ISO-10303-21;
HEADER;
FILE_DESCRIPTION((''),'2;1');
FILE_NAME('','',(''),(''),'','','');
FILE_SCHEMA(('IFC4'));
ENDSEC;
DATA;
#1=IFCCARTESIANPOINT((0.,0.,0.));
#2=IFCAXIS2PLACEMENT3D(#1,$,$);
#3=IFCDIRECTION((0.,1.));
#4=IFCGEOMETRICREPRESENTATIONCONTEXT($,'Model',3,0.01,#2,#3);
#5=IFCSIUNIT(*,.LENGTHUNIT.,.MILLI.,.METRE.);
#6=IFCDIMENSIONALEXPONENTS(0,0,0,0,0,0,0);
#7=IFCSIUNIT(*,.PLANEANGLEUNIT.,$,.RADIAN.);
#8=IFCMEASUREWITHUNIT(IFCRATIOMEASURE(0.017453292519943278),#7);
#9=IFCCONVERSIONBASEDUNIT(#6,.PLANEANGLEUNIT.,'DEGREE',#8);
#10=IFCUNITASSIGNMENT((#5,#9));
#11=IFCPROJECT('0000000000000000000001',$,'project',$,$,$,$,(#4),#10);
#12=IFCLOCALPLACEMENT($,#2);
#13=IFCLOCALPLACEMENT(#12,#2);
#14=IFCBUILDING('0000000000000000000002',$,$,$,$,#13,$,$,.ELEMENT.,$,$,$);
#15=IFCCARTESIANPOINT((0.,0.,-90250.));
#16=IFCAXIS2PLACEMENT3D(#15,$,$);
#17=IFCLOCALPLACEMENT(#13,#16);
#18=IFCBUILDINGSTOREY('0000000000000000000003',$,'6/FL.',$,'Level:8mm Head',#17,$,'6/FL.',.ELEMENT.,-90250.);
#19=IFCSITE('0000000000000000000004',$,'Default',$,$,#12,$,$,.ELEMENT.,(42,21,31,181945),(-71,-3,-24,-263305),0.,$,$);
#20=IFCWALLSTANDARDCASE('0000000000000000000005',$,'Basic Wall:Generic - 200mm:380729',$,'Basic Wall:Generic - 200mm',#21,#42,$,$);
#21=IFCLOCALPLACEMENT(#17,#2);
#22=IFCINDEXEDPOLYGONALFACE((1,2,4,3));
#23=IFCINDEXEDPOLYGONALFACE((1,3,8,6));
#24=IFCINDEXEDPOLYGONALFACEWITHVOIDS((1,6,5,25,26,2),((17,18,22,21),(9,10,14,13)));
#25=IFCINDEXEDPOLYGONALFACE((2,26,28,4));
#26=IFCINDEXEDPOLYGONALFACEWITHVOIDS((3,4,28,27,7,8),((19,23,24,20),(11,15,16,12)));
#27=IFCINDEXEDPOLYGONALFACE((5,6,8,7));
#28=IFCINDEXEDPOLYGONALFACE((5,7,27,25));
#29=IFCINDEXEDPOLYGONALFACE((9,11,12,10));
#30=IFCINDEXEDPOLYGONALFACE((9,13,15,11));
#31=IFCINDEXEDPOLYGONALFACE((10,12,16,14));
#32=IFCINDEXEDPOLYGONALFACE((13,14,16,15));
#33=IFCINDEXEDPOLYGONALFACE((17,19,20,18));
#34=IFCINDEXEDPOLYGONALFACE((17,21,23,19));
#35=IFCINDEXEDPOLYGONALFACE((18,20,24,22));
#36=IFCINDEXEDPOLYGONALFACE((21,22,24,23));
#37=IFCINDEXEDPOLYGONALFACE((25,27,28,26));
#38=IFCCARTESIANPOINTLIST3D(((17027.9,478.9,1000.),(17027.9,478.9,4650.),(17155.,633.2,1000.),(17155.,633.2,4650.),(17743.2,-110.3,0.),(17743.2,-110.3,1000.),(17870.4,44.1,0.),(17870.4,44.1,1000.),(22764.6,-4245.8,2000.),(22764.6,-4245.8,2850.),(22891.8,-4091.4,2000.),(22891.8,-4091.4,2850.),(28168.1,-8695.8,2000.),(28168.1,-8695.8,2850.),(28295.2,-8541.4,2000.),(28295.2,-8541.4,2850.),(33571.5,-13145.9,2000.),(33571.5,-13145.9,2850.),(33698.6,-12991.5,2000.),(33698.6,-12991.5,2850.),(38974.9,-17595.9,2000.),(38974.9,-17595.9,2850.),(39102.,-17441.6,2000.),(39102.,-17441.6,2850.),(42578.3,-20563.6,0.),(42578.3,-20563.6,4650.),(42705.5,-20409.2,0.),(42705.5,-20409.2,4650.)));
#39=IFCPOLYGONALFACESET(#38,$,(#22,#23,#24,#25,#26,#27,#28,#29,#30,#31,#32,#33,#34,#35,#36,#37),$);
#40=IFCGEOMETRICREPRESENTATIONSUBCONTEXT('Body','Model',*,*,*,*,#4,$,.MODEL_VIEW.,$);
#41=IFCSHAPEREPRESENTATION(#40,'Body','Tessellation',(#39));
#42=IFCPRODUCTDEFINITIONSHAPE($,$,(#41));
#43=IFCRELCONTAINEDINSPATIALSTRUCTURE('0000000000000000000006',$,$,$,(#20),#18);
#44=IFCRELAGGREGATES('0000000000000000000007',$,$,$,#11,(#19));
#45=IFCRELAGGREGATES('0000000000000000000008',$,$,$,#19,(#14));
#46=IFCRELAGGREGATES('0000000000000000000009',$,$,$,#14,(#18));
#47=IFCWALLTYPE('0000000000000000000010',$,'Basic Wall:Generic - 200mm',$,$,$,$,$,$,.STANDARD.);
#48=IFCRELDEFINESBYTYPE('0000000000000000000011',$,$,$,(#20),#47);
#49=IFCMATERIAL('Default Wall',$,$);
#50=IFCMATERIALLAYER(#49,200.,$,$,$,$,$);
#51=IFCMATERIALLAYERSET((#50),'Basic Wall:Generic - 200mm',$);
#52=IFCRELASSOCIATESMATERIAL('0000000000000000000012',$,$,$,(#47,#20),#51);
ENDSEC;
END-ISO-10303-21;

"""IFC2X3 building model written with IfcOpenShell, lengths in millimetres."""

from ifc_helpers import new_model, entity, si_unit, converted_unit, direction, frame, frame_2d, origin, place, context, subcontext, project, spatial, rectangle, extrude, material, layer, layer_set, layer_usage, type_object, element, save


model = new_model("IFC2X3")

# Units and contexts
model_context = context("Model", 3, precision=0.01, world=origin(), true_north=direction((0.0, 1.0)))
body_context = subcontext(model_context, "Body", "Model", "MODEL_VIEW")
ifc_project = project(units=[si_unit("LENGTHUNIT", "METRE", prefix="MILLI"), converted_unit("PLANEANGLEUNIT", "DEGREE", entity("IfcRatioMeasure", 0.017453292519943278), si_unit("PLANEANGLEUNIT", "RADIAN"), dimensions=[0, 0, 0, 0, 0, 0, 0])], contexts=[model_context])

# Site, building, storey
site_placement = place(None, origin())
site = spatial("IfcSite", under=ifc_project, at=site_placement, Name="Default", CompositionType="ELEMENT", RefLatitude=(42, 21, 31, 181945), RefLongitude=(-71, -3, -24, -263305), RefElevation=0.0)
building_placement = place(site_placement, origin())
building = spatial("IfcBuilding", under=site, at=building_placement, CompositionType="ELEMENT")
storey_placement = place(building_placement, frame((0.0, 0.0, -90250.0)))
storey = spatial("IfcBuildingStorey", under=building, at=storey_placement, Name="6/FL.", ObjectType="Level:8mm Head", LongName="6/FL.", CompositionType="ELEMENT", Elevation=-90250.0)

# Wall, openings
ifc_material_1 = material(Name="Default Wall")
ifc_layer = layer(ifc_material_1, 200.0)
ifc_layer_set = layer_set([ifc_layer], Name="Basic Wall:Generic - 200mm")
ifc_layer_usage = layer_usage(ifc_layer_set, "AXIS2", "NEGATIVE", 100.0)
wall_type = type_object("IfcWallType", Name="Basic Wall:Generic - 200mm", PredefinedType="STANDARD", material=ifc_layer_set)
wall_1_placement = place(storey_placement, frame((42641.9, -20486.4, 0.0), z_axis=(0.0, 0.0, 1.0), x_axis=(-0.771917, 0.635723, 0.0)))
wall_1 = element("IfcWallStandardCase", 1, at=wall_1_placement, inside=storey, type_object=wall_type, material=ifc_layer_usage, Name="Basic Wall:Generic - 200mm:380729", ObjectType="Basic Wall:Generic - 200mm", context=body_context, shape_type="SweptSolid", body=[
    extrude(rectangle(XDim=33100.0, YDim=200.0, at=frame_2d((16550.0, 0.0), x_axis=(-1.0, 0.0))), origin(), (0.0, 0.0, 1.0), 4650.0),
])
opening_1_placement = place(wall_1_placement, origin())
element("IfcOpeningElement", 2, at=opening_1_placement, cuts=wall_1, ObjectType="Opening", context=body_context, shape_type="SweptSolid", body=[
    extrude(rectangle(XDim=850.0, YDim=7000.0, at=frame_2d((0.0, 0.0), x_axis=(1.0, 0.0))), frame((8168.1, -100.0, 2425.0), z_axis=(0.0, 1.0, 0.0), x_axis=(0.0, 0.0, -1.0)), (0.0, 0.0, 1.0), 200.0),
])
opening_2_placement = place(wall_1_placement, origin())
element("IfcOpeningElement", 3, at=opening_2_placement, cuts=wall_1, ObjectType="Opening", context=body_context, shape_type="SweptSolid", body=[
    extrude(rectangle(XDim=850.0, YDim=7000.0, at=frame_2d((0.0, 0.0), x_axis=(1.0, 0.0))), frame((22168.1, -100.0, 2425.0), z_axis=(0.0, 1.0, 0.0), x_axis=(0.0, 0.0, -1.0)), (0.0, 0.0, 1.0), 200.0),
])
opening_3_placement = place(wall_1_placement, frame((45939.7, 11294.7, 0.0), z_axis=(0.0, 0.0, 1.0), x_axis=(-0.771917, -0.635723, 0.0)))
element("IfcOpeningElement", 4, at=opening_3_placement, cuts=wall_1, ObjectType="Opening", context=body_context, shape_type="SweptSolid", body=[
    extrude(rectangle(XDim=1000.0, YDim=1010.1, at=frame_2d((0.0, 0.0), x_axis=(1.0, 0.0))), frame((17488.6, 375.0, 500.0), z_axis=(-0.635723, -0.771917, 0.0), x_axis=(0.0, 0.0, -1.0)), (0.0, 0.0, 1.0), 1012.7),
])

save(model, "model.ifc")
